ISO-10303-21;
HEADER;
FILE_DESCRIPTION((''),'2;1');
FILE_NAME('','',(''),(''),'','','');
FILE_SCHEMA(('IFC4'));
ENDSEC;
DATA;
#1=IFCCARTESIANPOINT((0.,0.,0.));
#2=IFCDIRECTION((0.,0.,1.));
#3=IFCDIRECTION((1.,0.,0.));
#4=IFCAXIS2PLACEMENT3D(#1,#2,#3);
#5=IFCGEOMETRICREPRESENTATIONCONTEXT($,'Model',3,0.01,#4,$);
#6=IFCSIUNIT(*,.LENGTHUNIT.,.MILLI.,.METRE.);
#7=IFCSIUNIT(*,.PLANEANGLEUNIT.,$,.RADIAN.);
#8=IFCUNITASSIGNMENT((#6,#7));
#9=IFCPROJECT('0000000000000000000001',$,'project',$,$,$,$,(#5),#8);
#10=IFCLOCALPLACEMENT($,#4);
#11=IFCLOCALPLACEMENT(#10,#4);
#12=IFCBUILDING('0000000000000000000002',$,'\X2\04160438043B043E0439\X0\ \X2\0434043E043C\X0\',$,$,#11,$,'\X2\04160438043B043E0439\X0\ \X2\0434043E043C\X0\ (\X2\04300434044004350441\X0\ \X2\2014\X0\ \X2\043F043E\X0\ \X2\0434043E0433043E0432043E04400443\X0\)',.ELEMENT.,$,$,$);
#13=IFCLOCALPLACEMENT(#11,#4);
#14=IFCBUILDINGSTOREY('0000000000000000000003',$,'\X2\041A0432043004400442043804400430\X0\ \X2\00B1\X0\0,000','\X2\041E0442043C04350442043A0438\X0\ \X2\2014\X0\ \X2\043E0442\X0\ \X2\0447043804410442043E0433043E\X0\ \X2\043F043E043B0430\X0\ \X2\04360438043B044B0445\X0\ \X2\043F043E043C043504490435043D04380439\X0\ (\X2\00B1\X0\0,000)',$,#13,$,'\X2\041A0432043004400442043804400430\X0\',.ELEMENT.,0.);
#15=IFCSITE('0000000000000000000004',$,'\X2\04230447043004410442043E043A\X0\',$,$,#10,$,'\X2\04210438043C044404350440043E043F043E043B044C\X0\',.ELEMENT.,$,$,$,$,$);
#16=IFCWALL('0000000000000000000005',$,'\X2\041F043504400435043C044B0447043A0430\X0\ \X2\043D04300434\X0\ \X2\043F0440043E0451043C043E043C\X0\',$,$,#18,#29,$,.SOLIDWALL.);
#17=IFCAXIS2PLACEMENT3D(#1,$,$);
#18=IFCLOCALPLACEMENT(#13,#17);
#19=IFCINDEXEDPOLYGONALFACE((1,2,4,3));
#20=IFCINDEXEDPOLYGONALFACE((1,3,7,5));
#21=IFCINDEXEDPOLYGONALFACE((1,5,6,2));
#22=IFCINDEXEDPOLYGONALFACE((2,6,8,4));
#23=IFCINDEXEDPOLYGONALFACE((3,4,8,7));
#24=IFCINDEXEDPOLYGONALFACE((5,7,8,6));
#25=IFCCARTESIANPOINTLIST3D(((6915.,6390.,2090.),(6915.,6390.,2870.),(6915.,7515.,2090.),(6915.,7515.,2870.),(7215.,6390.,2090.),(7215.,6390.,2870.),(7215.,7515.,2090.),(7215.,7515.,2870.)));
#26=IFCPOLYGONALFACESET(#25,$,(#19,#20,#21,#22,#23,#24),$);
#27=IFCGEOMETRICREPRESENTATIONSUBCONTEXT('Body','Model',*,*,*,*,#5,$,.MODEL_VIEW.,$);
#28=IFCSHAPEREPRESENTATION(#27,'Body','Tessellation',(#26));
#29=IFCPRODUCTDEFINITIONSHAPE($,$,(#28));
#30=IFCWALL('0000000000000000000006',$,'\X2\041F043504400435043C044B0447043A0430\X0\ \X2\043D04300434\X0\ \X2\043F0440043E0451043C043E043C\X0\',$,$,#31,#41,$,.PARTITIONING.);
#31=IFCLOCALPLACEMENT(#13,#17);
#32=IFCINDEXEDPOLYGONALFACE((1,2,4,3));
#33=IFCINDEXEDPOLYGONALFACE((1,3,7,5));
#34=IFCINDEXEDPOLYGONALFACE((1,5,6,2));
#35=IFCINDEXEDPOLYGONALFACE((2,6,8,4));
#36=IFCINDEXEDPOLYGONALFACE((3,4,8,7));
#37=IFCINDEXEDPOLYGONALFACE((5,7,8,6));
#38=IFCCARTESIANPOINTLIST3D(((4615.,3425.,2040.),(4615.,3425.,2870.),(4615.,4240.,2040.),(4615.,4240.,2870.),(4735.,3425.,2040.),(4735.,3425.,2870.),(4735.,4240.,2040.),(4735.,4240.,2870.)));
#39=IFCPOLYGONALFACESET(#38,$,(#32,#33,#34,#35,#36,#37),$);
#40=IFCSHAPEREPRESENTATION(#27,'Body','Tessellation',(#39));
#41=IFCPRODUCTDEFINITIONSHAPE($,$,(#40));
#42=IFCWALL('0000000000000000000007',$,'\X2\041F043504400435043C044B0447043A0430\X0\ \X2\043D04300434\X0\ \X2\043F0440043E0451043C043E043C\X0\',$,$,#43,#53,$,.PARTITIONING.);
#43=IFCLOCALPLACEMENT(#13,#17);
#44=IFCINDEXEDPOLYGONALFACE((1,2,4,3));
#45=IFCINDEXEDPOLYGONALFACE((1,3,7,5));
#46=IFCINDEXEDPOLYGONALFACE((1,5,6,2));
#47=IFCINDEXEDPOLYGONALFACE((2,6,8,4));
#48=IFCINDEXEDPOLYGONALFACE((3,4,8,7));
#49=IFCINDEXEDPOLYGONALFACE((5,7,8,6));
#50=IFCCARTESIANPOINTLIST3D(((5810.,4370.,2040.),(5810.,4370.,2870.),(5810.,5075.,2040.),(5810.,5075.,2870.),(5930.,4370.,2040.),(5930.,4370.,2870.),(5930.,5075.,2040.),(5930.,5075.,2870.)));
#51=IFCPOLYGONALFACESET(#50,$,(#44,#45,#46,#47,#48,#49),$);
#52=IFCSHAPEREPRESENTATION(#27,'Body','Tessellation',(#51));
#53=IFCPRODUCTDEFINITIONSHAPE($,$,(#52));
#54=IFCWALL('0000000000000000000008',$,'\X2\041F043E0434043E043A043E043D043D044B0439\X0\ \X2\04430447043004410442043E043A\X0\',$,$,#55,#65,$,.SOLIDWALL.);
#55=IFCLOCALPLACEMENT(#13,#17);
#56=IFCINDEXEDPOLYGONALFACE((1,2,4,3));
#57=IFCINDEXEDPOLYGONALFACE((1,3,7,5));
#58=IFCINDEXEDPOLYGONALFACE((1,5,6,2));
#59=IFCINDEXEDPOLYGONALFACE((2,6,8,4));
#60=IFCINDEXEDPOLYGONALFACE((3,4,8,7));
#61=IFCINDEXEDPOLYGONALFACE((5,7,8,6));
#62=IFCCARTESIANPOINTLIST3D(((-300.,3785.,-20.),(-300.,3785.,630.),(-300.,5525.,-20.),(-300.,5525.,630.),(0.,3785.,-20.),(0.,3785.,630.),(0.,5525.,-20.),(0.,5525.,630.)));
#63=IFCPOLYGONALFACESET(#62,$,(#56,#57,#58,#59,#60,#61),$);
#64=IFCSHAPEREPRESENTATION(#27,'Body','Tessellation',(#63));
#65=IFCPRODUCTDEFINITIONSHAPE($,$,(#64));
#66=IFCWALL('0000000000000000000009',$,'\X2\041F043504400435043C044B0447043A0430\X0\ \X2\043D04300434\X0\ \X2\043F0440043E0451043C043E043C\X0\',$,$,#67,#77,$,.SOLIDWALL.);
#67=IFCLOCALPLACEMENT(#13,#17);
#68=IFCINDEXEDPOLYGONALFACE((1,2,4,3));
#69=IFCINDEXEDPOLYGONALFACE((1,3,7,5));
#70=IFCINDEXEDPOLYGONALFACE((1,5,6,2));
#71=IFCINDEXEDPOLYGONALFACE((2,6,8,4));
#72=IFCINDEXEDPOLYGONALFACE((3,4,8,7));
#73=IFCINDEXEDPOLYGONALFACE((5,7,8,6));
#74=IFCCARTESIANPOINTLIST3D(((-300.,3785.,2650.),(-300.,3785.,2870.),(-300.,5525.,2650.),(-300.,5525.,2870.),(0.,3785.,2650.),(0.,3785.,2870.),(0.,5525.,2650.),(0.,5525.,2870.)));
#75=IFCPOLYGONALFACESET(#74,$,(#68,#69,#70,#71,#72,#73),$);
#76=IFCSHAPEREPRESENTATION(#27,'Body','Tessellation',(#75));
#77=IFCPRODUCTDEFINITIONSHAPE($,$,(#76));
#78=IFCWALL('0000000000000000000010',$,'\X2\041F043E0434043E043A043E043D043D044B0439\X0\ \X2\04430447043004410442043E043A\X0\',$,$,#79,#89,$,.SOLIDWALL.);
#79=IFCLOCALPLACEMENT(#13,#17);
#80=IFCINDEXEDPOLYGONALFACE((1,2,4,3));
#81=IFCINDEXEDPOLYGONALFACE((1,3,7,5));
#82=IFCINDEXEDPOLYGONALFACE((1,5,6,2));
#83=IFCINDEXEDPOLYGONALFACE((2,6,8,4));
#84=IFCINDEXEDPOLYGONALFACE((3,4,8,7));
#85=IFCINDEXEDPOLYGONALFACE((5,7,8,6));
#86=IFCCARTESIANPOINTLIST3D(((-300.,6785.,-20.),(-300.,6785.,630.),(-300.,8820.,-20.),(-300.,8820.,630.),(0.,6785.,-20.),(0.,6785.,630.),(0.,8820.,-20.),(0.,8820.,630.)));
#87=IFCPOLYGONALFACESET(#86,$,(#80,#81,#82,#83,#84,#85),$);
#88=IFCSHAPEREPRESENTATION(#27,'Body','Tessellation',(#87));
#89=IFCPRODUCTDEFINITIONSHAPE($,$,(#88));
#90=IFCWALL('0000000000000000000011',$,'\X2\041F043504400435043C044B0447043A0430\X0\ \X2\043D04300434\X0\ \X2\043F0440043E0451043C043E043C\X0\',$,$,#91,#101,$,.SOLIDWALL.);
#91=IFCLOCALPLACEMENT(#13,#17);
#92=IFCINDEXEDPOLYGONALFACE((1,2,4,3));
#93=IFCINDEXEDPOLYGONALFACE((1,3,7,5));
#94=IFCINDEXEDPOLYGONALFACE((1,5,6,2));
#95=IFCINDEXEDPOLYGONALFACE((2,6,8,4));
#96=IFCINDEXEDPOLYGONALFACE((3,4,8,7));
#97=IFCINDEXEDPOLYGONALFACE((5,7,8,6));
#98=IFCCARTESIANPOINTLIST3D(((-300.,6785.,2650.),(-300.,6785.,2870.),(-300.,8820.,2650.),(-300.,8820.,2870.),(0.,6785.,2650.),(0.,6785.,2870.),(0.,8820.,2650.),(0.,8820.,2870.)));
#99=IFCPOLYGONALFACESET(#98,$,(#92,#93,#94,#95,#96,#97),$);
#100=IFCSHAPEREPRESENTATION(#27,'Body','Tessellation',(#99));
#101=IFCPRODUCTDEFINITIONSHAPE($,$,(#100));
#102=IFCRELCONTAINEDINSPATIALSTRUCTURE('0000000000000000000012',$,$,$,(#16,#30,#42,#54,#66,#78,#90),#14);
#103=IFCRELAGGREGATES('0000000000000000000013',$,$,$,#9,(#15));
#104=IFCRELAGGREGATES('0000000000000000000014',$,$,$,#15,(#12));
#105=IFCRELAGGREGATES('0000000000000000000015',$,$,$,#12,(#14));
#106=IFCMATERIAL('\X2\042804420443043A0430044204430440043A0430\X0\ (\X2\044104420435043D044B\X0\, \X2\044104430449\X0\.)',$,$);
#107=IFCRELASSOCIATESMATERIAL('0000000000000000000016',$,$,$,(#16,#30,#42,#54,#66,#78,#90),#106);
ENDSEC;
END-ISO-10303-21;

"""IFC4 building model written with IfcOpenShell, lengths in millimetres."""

from ifc_helpers import new_model, si_unit, frame, origin, origin_with_axes, place, context, subcontext, project, spatial, polyline, outline, extrude, material, element, save


model = new_model("IFC4")

# Units and contexts
model_context = context("Model", 3, precision=0.01, world=origin_with_axes())
body_context = subcontext(model_context, "Body", "Model", "MODEL_VIEW")
ifc_project = project(units=[si_unit("LENGTHUNIT", "METRE", prefix="MILLI"), si_unit("PLANEANGLEUNIT", "RADIAN")], contexts=[model_context])

# Site, building, storey
site_placement = place(None, origin_with_axes())
site = spatial("IfcSite", under=ifc_project, at=site_placement, Name="Участок", LongName="Симферополь", CompositionType="ELEMENT")
building_placement = place(site_placement, origin_with_axes())
building = spatial("IfcBuilding", under=site, at=building_placement, Name="Жилой дом", LongName="Жилой дом (адрес — по договору)", CompositionType="ELEMENT")
storey_placement = place(building_placement, origin_with_axes())
storey = spatial("IfcBuildingStorey", under=building, at=storey_placement, Name="Квартира ±0,000", Description="Отметки — от чистого пола жилых помещений (±0,000)", LongName="Квартира", CompositionType="ELEMENT", Elevation=0.0)

# Walls
ifc_material_1 = material(Name="Штукатурка (стены, сущ.)")
wall_1_placement = place(storey_placement, frame((6915.0, 6390.0, 2090.0)))
element("IfcWall", 1, at=wall_1_placement, inside=storey, material=ifc_material_1, Name="Перемычка над проёмом", PredefinedType="SOLIDWALL", context=body_context, shape_type="SweptSolid", body=[
    extrude(outline(polyline([(0.0, 0.0), (300.0, 0.0), (300.0, 1125.0), (0.0, 1125.0), (0.0, 0.0)])), origin(), (0.0, 0.0, 1.0), 780.0),
])
wall_2_placement = place(storey_placement, frame((4615.0, 3425.0, 2040.0)))
element("IfcWall", 2, at=wall_2_placement, inside=storey, material=ifc_material_1, Name="Перемычка над проёмом", PredefinedType="PARTITIONING", context=body_context, shape_type="SweptSolid", body=[
    extrude(outline(polyline([(0.0, 0.0), (120.0, 0.0), (120.0, 815.0), (0.0, 815.0), (0.0, 0.0)])), origin(), (0.0, 0.0, 1.0), 830.0),
])
wall_3_placement = place(storey_placement, frame((5810.0, 4370.0, 2040.0)))
element("IfcWall", 3, at=wall_3_placement, inside=storey, material=ifc_material_1, Name="Перемычка над проёмом", PredefinedType="PARTITIONING", context=body_context, shape_type="SweptSolid", body=[
    extrude(outline(polyline([(0.0, 0.0), (120.0, 0.0), (120.0, 705.0), (0.0, 705.0), (0.0, 0.0)])), origin(), (0.0, 0.0, 1.0), 830.0),
])
wall_4_placement = place(storey_placement, frame((-300.0, 3785.0, -20.0)))
element("IfcWall", 4, at=wall_4_placement, inside=storey, material=ifc_material_1, Name="Подоконный участок", PredefinedType="SOLIDWALL", context=body_context, shape_type="SweptSolid", body=[
    extrude(outline(polyline([(0.0, 0.0), (300.0, 0.0), (300.0, 1740.0), (0.0, 1740.0), (0.0, 0.0)])), origin(), (0.0, 0.0, 1.0), 650.0),
])
wall_5_placement = place(storey_placement, frame((-300.0, 3785.0, 2650.0)))
element("IfcWall", 5, at=wall_5_placement, inside=storey, material=ifc_material_1, Name="Перемычка над проёмом", PredefinedType="SOLIDWALL", context=body_context, shape_type="SweptSolid", body=[
    extrude(outline(polyline([(0.0, 0.0), (300.0, 0.0), (300.0, 1740.0), (0.0, 1740.0), (0.0, 0.0)])), origin(), (0.0, 0.0, 1.0), 220.0),
])
wall_6_placement = place(storey_placement, frame((-300.0, 6785.0, -20.0)))
element("IfcWall", 6, at=wall_6_placement, inside=storey, material=ifc_material_1, Name="Подоконный участок", PredefinedType="SOLIDWALL", context=body_context, shape_type="SweptSolid", body=[
    extrude(outline(polyline([(0.0, 0.0), (300.0, 0.0), (300.0, 2035.0), (0.0, 2035.0), (0.0, 0.0)])), origin(), (0.0, 0.0, 1.0), 650.0),
])
wall_7_placement = place(storey_placement, frame((-300.0, 6785.0, 2650.0)))
element("IfcWall", 7, at=wall_7_placement, inside=storey, material=ifc_material_1, Name="Перемычка над проёмом", PredefinedType="SOLIDWALL", context=body_context, shape_type="SweptSolid", body=[
    extrude(outline(polyline([(0.0, 0.0), (300.0, 0.0), (300.0, 2035.0), (0.0, 2035.0), (0.0, 0.0)])), origin(), (0.0, 0.0, 1.0), 220.0),
])

save(model, "model.ifc")
